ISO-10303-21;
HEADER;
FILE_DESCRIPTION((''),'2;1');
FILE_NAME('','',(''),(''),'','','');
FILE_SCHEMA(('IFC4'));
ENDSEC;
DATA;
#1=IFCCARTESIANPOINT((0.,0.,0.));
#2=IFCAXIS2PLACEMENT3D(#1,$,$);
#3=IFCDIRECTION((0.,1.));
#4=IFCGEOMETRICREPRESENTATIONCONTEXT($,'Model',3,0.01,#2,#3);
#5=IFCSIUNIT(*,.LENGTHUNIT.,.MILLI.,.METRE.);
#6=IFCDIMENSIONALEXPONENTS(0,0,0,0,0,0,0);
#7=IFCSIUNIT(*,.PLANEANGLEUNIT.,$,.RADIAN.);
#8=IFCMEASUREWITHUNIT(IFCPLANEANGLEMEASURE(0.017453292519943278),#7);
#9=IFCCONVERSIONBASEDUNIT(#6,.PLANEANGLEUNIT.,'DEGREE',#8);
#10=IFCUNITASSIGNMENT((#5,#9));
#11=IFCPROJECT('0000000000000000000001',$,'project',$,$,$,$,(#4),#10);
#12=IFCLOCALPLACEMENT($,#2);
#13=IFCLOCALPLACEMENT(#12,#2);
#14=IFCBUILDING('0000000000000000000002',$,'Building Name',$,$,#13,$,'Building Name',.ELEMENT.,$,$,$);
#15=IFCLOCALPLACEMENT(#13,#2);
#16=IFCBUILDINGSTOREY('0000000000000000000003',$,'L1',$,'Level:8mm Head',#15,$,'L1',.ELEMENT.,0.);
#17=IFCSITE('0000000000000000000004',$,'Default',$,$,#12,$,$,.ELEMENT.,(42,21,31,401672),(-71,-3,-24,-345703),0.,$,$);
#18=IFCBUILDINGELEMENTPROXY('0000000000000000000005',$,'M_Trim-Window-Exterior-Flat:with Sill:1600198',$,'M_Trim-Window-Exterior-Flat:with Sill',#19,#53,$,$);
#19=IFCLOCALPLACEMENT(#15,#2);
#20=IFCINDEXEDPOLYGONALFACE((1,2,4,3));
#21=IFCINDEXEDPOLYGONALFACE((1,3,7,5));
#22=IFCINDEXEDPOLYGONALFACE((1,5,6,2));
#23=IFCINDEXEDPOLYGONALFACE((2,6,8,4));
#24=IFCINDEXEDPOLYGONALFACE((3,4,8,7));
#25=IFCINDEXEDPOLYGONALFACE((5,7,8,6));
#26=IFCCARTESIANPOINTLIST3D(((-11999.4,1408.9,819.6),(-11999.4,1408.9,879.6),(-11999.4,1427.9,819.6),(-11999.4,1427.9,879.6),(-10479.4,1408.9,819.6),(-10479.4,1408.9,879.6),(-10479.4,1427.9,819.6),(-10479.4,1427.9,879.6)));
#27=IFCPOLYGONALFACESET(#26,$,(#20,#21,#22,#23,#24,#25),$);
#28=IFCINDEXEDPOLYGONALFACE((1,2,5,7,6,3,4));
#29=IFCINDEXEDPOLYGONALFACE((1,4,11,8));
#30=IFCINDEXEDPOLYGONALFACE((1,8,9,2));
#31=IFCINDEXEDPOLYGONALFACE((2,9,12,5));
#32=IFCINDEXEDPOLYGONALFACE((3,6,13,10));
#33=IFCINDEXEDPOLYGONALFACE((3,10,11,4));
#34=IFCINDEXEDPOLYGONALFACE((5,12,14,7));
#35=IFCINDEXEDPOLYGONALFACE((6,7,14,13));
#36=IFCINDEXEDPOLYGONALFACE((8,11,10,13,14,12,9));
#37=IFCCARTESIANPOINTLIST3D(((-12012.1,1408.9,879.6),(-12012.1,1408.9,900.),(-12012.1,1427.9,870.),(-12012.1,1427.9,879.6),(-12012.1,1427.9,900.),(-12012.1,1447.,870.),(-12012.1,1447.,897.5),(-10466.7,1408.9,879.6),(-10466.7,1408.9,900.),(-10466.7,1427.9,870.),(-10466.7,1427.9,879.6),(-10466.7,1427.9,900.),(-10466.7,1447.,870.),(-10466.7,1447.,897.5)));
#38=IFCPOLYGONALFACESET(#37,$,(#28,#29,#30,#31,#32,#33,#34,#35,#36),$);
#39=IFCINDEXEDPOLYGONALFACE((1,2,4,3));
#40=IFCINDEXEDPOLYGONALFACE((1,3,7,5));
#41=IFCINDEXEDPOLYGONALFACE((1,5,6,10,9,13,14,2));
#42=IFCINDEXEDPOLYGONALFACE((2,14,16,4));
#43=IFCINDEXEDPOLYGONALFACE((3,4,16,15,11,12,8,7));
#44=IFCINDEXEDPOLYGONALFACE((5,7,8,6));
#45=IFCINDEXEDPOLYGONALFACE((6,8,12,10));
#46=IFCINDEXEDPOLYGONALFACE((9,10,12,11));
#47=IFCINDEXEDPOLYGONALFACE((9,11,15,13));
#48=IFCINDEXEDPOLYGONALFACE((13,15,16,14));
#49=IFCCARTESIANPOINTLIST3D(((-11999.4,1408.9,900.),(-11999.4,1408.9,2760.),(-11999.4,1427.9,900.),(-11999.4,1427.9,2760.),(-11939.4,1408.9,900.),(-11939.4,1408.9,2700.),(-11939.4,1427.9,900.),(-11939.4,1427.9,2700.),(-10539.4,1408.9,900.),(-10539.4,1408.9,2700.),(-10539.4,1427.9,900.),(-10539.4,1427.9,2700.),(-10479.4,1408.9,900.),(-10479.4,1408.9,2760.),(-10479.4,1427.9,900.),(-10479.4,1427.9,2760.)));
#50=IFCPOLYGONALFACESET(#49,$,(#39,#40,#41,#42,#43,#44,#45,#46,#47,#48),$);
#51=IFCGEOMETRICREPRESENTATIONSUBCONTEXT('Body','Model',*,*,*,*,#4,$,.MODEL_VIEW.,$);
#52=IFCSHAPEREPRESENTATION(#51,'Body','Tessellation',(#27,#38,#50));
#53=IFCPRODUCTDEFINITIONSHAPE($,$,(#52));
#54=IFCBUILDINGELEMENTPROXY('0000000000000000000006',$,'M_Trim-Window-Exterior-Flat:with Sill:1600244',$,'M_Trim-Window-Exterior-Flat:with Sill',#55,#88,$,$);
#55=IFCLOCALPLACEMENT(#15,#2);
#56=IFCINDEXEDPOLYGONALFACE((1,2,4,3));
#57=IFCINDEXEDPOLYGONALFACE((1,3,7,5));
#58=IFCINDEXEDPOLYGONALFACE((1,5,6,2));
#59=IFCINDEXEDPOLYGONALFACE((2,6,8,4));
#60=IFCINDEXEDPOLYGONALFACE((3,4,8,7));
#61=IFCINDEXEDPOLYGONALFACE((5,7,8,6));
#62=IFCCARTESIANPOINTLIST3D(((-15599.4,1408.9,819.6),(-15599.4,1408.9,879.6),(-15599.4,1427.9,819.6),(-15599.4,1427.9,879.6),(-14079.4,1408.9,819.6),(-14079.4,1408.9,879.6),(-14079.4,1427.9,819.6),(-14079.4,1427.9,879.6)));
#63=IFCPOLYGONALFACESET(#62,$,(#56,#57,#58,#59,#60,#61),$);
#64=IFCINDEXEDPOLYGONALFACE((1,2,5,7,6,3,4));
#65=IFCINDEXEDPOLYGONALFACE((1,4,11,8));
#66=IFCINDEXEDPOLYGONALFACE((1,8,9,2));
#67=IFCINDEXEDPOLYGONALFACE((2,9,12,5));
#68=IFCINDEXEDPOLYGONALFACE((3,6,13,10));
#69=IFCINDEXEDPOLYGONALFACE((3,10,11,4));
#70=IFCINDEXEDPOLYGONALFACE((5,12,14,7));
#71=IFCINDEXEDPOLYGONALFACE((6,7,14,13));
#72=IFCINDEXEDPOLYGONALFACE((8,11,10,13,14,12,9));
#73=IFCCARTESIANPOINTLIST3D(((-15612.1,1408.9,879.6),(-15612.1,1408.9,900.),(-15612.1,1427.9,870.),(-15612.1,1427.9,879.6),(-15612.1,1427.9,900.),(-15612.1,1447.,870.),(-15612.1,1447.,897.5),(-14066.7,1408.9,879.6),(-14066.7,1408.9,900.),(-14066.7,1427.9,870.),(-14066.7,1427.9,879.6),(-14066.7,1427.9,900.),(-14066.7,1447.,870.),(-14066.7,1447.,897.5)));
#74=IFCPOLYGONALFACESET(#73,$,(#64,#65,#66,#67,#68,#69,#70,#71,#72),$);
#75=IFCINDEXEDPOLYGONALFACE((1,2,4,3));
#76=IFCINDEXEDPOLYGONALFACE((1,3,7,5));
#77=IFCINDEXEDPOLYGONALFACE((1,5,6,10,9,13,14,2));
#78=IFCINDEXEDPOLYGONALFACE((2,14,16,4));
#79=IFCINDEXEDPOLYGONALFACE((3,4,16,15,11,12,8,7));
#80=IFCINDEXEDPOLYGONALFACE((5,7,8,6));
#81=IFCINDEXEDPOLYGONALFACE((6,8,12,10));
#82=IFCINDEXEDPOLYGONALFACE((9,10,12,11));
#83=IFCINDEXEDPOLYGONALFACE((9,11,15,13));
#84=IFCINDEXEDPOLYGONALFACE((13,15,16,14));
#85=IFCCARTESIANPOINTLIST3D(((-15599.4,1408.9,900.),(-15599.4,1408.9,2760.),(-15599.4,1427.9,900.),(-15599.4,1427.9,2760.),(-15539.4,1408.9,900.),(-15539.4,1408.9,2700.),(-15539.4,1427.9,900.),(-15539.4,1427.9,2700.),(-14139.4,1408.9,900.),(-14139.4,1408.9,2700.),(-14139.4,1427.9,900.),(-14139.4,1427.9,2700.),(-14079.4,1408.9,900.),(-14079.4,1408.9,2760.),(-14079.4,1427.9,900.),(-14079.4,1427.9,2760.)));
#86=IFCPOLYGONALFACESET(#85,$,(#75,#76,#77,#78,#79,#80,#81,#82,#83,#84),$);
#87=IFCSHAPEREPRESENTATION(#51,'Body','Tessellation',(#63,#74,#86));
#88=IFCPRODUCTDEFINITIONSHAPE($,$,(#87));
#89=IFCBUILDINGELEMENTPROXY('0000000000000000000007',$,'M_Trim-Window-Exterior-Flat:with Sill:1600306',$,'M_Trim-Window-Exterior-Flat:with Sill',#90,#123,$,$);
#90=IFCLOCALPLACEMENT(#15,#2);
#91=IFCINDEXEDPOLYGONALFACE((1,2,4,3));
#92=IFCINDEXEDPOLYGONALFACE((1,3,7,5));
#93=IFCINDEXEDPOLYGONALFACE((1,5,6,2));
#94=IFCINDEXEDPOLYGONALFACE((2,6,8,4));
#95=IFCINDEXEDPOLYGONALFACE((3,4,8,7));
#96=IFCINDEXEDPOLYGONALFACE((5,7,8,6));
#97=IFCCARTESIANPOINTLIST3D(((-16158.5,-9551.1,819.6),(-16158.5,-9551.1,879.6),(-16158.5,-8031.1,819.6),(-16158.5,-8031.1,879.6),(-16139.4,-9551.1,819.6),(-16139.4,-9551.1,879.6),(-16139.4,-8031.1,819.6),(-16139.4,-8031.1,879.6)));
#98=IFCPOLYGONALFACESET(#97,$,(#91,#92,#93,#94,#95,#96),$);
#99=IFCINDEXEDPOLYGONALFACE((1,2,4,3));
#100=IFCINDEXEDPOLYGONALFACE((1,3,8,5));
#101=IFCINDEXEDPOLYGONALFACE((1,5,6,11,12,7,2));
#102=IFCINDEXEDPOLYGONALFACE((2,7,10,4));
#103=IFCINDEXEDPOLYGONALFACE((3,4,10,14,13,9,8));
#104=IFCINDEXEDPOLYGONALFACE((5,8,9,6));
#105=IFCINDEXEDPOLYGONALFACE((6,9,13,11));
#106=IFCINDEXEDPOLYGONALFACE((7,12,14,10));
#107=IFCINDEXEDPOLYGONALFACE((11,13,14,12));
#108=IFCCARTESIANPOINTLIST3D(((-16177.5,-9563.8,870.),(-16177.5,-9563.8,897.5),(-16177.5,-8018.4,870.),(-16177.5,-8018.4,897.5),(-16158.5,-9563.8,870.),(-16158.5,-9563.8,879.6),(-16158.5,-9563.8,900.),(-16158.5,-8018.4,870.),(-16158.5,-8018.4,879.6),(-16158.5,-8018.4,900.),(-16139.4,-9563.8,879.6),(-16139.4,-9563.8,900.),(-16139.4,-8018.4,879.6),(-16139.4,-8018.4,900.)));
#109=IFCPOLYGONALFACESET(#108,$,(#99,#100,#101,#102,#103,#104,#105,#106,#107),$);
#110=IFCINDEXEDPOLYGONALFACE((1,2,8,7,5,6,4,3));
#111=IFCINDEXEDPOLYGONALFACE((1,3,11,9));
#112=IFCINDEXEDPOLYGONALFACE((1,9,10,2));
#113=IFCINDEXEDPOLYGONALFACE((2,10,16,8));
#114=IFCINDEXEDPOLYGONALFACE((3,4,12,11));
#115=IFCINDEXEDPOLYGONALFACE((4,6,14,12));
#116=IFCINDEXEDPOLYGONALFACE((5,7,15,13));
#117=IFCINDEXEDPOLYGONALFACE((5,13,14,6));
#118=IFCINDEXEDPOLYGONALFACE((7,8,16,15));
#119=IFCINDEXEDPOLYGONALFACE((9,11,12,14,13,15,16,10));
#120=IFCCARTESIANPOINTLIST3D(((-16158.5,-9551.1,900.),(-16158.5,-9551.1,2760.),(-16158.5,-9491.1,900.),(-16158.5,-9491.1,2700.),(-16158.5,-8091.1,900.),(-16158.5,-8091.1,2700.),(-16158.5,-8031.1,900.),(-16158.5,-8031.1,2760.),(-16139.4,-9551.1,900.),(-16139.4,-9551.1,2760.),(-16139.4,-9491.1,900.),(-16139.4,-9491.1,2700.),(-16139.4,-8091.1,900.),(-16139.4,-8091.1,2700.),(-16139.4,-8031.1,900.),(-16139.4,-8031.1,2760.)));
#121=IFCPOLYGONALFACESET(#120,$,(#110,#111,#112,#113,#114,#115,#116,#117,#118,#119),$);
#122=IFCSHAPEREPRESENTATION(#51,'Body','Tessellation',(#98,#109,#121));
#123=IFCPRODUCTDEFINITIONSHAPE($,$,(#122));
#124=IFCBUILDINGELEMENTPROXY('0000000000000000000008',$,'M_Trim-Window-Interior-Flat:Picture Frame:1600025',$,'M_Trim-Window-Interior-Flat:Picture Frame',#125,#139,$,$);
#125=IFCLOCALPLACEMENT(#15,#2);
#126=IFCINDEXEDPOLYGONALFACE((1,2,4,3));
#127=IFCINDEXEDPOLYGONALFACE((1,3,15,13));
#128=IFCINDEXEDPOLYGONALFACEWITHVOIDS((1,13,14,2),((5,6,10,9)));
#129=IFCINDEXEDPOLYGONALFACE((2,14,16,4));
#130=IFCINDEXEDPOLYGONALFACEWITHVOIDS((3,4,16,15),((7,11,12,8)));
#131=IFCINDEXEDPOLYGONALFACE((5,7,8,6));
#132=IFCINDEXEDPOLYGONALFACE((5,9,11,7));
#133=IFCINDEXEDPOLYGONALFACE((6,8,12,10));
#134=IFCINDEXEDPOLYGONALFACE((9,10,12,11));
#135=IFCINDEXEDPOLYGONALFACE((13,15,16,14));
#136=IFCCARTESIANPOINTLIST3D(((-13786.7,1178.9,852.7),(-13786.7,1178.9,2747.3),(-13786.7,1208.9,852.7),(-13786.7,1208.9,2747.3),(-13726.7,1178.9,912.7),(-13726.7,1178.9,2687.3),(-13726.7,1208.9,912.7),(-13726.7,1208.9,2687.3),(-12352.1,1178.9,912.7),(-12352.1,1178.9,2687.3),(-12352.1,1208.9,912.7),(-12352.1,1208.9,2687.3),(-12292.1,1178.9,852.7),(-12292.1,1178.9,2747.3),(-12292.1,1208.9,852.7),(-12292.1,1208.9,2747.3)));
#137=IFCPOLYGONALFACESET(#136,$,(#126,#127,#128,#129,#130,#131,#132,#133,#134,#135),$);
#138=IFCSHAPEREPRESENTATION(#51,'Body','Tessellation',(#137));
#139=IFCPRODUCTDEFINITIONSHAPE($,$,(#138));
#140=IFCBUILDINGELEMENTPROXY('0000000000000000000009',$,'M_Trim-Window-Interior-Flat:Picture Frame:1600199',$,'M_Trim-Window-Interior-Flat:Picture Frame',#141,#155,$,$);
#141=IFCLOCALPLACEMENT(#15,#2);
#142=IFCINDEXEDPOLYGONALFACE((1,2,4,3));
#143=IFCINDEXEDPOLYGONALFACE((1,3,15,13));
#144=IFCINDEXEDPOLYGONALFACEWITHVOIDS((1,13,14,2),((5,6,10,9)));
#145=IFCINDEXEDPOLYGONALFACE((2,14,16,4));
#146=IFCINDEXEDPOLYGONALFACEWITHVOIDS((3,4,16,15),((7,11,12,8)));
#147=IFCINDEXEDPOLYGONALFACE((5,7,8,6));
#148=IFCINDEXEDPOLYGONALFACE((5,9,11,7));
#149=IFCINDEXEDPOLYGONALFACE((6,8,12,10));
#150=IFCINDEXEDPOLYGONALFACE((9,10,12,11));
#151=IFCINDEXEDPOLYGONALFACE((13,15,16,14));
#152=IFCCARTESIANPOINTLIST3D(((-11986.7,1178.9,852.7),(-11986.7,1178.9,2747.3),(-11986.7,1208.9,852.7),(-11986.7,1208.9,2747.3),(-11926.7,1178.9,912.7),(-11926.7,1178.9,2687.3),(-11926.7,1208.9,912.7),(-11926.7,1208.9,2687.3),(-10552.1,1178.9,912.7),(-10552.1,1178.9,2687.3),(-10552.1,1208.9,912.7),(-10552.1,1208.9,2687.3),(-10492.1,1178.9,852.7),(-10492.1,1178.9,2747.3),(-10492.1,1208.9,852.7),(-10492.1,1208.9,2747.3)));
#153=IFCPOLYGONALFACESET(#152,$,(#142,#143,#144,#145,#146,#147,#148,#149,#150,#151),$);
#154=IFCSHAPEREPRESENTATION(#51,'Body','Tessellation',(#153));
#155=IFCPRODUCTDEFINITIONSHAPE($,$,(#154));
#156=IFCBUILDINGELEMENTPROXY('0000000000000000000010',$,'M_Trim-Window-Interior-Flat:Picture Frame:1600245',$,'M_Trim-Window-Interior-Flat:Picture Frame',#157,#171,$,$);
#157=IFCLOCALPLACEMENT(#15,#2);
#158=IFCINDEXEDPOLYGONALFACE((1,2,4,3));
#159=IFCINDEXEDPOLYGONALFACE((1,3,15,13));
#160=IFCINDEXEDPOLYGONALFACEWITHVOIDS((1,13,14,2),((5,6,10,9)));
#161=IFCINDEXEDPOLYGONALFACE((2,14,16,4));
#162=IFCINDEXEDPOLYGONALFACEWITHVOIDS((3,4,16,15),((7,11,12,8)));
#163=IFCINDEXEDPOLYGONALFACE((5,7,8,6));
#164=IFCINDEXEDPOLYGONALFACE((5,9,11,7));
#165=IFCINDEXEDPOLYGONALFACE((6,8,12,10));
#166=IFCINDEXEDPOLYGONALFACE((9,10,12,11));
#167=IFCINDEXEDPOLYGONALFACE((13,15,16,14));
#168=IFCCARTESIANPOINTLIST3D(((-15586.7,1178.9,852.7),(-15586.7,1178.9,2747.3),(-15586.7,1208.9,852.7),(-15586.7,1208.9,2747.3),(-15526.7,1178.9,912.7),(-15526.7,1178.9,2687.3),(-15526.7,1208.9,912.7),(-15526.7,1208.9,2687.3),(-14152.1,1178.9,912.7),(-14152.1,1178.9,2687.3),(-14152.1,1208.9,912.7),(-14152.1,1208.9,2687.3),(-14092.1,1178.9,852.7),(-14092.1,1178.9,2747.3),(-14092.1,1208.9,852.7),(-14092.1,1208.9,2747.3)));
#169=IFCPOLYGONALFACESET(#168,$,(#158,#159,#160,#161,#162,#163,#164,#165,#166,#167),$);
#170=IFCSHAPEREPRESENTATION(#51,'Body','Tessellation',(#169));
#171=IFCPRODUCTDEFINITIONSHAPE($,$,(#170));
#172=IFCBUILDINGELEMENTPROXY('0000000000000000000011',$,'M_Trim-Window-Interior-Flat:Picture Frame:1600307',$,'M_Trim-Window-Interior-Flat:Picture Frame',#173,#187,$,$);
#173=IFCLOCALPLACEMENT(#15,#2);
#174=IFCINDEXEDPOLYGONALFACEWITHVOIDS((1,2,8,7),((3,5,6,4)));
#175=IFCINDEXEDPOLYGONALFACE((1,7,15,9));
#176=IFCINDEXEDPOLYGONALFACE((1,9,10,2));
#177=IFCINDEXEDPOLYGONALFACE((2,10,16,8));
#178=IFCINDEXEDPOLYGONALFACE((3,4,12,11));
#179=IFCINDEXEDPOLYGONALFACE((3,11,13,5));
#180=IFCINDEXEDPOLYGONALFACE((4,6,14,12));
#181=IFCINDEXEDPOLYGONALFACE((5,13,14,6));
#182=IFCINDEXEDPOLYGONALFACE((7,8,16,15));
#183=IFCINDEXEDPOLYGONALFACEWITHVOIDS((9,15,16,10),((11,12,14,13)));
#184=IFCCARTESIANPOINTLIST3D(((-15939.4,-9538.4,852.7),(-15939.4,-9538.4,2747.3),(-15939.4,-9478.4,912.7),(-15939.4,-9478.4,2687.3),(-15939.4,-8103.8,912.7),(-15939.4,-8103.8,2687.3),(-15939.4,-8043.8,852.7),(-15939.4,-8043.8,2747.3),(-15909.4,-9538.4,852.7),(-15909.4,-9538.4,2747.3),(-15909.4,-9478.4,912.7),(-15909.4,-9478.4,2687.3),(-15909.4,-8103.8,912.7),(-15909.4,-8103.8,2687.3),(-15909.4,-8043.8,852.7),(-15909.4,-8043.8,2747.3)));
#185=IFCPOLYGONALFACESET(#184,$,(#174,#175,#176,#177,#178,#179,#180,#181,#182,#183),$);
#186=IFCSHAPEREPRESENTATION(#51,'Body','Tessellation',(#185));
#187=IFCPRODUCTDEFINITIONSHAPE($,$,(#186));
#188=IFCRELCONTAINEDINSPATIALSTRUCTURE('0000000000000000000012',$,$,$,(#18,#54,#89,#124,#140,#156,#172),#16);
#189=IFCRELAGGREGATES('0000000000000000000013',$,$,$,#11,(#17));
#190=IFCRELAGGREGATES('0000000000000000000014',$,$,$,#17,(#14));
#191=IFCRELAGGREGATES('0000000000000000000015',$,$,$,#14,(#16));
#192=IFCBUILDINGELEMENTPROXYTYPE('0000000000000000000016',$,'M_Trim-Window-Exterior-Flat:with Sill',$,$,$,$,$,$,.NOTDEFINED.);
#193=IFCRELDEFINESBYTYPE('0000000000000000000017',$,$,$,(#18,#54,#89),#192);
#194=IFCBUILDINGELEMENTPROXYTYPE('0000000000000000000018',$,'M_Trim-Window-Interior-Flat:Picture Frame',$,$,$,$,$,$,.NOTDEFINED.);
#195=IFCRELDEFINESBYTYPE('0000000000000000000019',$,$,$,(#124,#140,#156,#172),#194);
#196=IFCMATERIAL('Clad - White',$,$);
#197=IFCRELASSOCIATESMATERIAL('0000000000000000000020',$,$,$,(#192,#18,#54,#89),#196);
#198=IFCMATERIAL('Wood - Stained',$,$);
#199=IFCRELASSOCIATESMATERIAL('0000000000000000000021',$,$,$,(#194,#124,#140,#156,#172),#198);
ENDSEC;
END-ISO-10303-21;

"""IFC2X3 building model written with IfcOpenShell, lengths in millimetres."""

from ifc_helpers import new_model, entity, si_unit, converted_unit, direction, frame, frame_2d, origin, place, context, subcontext, project, spatial, polyline, rectangle, outline, extrude, source, transform, mapped, material, type_object, type_shapes, element, save


model = new_model("IFC2X3")

# Units and contexts
model_context = context("Model", 3, precision=0.01, world=origin(), true_north=direction((0.0, 1.0)))
body_context = subcontext(model_context, "Body", "Model", "MODEL_VIEW")
ifc_project = project(units=[si_unit("LENGTHUNIT", "METRE", prefix="MILLI"), converted_unit("PLANEANGLEUNIT", "DEGREE", entity("IfcPlaneAngleMeasure", 0.017453292519943278), si_unit("PLANEANGLEUNIT", "RADIAN"), dimensions=[0, 0, 0, 0, 0, 0, 0])], contexts=[model_context])

# Site, building, storey
site_placement = place(None, origin())
site = spatial("IfcSite", under=ifc_project, at=site_placement, Name="Default", CompositionType="ELEMENT", RefLatitude=(42, 21, 31, 401672), RefLongitude=(-71, -3, -24, -345703), RefElevation=0.0)
building_placement = place(site_placement, origin())
building = spatial("IfcBuilding", under=site, at=building_placement, Name="Building Name", LongName="Building Name", CompositionType="ELEMENT")
storey_placement = place(building_placement, origin())
storey = spatial("IfcBuildingStorey", under=building, at=storey_placement, Name="L1", ObjectType="Level:8mm Head", LongName="L1", CompositionType="ELEMENT", Elevation=0.0)

# Building element proxies
ifc_material_1 = material(Name="Clad - White")
ifc_material_2 = material(Name="Wood - Stained")
building_element_proxy_type_1 = type_object("IfcBuildingElementProxyType", Name="M_Trim-Window-Exterior-Flat:with Sill", PredefinedType="NOTDEFINED", material=ifc_material_1)
shared_shape_1 = source(origin(), body_context, "Body", "SweptSolid", [
    extrude(rectangle(XDim=1520.0, YDim=60.0, at=frame_2d((0.0, 0.0), x_axis=(1.0, 0.0))), frame((0.0, -1850.4, 0.0), z_axis=(0.0, 0.0, 1.0), x_axis=(-1.0, 0.0, 0.0)), (0.0, 0.0, 1.0), 19.0),
    extrude(outline(polyline([(-19.0, -15.2), (0.0, -15.2), (0.0, -5.7), (19.0, -5.7), (19.0, 14.8), (0.0, 14.8), (-19.0, 12.3), (-19.0, -15.2)])), frame((-772.7, -1814.8, 19.0), z_axis=(1.0, 0.0, 0.0), x_axis=(0.0, 0.0, -1.0)), (0.0, 0.0, 1.0), 1545.4),
    extrude(outline(polyline([(-945.0, -760.0), (915.0, -760.0), (915.0, -700.0), (-885.0, -700.0), (-885.0, 700.0), (915.0, 700.0), (915.0, 760.0), (-945.0, 760.0), (-945.0, -760.0)])), frame((0.0, -885.0, 0.0), z_axis=(0.0, 0.0, 1.0), x_axis=(0.0, -1.0, 0.0)), (0.0, 0.0, 1.0), 19.0),
])
type_shapes(building_element_proxy_type_1, [shared_shape_1])
for number, where, z_axis, x_axis, name in (
    (1, (-11239.4, 1408.9, 2700.0), (0.0, 1.0, 0.0), (-1.0, 0.0, 0.0), "M_Trim-Window-Exterior-Flat:with Sill:1600198"),
    (2, (-14839.4, 1408.9, 2700.0), (0.0, 1.0, 0.0), (-1.0, 0.0, 0.0), "M_Trim-Window-Exterior-Flat:with Sill:1600244"),
    (3, (-16139.4, -8791.1, 2700.0), (-1.0, 0.0, 0.0), (0.0, -1.0, 0.0), "M_Trim-Window-Exterior-Flat:with Sill:1600306"),
):
    element("IfcBuildingElementProxy", number, at=place(storey_placement, frame(where, z_axis=z_axis, x_axis=x_axis)), inside=storey, type_object=building_element_proxy_type_1, material=ifc_material_1, Name=name, ObjectType="M_Trim-Window-Exterior-Flat:with Sill", context=body_context, shape_type="MappedRepresentation", body=[
        mapped(shared_shape_1, transform((0.0, 0.0, 0.0), scale=1.0)),
    ])
building_element_proxy_type_2 = type_object("IfcBuildingElementProxyType", Name="M_Trim-Window-Interior-Flat:Picture Frame", PredefinedType="NOTDEFINED", material=ifc_material_2)
shared_shape_2 = source(origin(), body_context, "Body", "SweptSolid", [
    extrude(outline(polyline([(-747.3, -947.3), (747.3, -947.3), (747.3, 947.3), (-747.3, 947.3), (-747.3, -947.3)]), holes=[polyline([(-687.3, -887.3), (-687.3, 887.3), (687.3, 887.3), (687.3, -887.3), (-687.3, -887.3)])]), frame((0.0, -900.0, 0.0), z_axis=(0.0, 0.0, 1.0), x_axis=(-1.0, 0.0, 0.0)), (0.0, 0.0, 1.0), 30.0),
])
type_shapes(building_element_proxy_type_2, [shared_shape_2])
for number, where, z_axis, x_axis, name in (
    (4, (-13039.4, 1208.9, 2700.0), (0.0, -1.0, 0.0), (1.0, 0.0, 0.0), "M_Trim-Window-Interior-Flat:Picture Frame:1600025"),
    (5, (-11239.4, 1208.9, 2700.0), (0.0, -1.0, 0.0), (1.0, 0.0, 0.0), "M_Trim-Window-Interior-Flat:Picture Frame:1600199"),
    (6, (-14839.4, 1208.9, 2700.0), (0.0, -1.0, 0.0), (1.0, 0.0, 0.0), "M_Trim-Window-Interior-Flat:Picture Frame:1600245"),
    (7, (-15939.4, -8791.1, 2700.0), (1.0, 0.0, 0.0), (0.0, 1.0, 0.0), "M_Trim-Window-Interior-Flat:Picture Frame:1600307"),
):
    element("IfcBuildingElementProxy", number, at=place(storey_placement, frame(where, z_axis=z_axis, x_axis=x_axis)), inside=storey, type_object=building_element_proxy_type_2, material=ifc_material_2, Name=name, ObjectType="M_Trim-Window-Interior-Flat:Picture Frame", context=body_context, shape_type="MappedRepresentation", body=[
        mapped(shared_shape_2, transform((0.0, 0.0, 0.0), scale=1.0)),
    ])

save(model, "model.ifc")
